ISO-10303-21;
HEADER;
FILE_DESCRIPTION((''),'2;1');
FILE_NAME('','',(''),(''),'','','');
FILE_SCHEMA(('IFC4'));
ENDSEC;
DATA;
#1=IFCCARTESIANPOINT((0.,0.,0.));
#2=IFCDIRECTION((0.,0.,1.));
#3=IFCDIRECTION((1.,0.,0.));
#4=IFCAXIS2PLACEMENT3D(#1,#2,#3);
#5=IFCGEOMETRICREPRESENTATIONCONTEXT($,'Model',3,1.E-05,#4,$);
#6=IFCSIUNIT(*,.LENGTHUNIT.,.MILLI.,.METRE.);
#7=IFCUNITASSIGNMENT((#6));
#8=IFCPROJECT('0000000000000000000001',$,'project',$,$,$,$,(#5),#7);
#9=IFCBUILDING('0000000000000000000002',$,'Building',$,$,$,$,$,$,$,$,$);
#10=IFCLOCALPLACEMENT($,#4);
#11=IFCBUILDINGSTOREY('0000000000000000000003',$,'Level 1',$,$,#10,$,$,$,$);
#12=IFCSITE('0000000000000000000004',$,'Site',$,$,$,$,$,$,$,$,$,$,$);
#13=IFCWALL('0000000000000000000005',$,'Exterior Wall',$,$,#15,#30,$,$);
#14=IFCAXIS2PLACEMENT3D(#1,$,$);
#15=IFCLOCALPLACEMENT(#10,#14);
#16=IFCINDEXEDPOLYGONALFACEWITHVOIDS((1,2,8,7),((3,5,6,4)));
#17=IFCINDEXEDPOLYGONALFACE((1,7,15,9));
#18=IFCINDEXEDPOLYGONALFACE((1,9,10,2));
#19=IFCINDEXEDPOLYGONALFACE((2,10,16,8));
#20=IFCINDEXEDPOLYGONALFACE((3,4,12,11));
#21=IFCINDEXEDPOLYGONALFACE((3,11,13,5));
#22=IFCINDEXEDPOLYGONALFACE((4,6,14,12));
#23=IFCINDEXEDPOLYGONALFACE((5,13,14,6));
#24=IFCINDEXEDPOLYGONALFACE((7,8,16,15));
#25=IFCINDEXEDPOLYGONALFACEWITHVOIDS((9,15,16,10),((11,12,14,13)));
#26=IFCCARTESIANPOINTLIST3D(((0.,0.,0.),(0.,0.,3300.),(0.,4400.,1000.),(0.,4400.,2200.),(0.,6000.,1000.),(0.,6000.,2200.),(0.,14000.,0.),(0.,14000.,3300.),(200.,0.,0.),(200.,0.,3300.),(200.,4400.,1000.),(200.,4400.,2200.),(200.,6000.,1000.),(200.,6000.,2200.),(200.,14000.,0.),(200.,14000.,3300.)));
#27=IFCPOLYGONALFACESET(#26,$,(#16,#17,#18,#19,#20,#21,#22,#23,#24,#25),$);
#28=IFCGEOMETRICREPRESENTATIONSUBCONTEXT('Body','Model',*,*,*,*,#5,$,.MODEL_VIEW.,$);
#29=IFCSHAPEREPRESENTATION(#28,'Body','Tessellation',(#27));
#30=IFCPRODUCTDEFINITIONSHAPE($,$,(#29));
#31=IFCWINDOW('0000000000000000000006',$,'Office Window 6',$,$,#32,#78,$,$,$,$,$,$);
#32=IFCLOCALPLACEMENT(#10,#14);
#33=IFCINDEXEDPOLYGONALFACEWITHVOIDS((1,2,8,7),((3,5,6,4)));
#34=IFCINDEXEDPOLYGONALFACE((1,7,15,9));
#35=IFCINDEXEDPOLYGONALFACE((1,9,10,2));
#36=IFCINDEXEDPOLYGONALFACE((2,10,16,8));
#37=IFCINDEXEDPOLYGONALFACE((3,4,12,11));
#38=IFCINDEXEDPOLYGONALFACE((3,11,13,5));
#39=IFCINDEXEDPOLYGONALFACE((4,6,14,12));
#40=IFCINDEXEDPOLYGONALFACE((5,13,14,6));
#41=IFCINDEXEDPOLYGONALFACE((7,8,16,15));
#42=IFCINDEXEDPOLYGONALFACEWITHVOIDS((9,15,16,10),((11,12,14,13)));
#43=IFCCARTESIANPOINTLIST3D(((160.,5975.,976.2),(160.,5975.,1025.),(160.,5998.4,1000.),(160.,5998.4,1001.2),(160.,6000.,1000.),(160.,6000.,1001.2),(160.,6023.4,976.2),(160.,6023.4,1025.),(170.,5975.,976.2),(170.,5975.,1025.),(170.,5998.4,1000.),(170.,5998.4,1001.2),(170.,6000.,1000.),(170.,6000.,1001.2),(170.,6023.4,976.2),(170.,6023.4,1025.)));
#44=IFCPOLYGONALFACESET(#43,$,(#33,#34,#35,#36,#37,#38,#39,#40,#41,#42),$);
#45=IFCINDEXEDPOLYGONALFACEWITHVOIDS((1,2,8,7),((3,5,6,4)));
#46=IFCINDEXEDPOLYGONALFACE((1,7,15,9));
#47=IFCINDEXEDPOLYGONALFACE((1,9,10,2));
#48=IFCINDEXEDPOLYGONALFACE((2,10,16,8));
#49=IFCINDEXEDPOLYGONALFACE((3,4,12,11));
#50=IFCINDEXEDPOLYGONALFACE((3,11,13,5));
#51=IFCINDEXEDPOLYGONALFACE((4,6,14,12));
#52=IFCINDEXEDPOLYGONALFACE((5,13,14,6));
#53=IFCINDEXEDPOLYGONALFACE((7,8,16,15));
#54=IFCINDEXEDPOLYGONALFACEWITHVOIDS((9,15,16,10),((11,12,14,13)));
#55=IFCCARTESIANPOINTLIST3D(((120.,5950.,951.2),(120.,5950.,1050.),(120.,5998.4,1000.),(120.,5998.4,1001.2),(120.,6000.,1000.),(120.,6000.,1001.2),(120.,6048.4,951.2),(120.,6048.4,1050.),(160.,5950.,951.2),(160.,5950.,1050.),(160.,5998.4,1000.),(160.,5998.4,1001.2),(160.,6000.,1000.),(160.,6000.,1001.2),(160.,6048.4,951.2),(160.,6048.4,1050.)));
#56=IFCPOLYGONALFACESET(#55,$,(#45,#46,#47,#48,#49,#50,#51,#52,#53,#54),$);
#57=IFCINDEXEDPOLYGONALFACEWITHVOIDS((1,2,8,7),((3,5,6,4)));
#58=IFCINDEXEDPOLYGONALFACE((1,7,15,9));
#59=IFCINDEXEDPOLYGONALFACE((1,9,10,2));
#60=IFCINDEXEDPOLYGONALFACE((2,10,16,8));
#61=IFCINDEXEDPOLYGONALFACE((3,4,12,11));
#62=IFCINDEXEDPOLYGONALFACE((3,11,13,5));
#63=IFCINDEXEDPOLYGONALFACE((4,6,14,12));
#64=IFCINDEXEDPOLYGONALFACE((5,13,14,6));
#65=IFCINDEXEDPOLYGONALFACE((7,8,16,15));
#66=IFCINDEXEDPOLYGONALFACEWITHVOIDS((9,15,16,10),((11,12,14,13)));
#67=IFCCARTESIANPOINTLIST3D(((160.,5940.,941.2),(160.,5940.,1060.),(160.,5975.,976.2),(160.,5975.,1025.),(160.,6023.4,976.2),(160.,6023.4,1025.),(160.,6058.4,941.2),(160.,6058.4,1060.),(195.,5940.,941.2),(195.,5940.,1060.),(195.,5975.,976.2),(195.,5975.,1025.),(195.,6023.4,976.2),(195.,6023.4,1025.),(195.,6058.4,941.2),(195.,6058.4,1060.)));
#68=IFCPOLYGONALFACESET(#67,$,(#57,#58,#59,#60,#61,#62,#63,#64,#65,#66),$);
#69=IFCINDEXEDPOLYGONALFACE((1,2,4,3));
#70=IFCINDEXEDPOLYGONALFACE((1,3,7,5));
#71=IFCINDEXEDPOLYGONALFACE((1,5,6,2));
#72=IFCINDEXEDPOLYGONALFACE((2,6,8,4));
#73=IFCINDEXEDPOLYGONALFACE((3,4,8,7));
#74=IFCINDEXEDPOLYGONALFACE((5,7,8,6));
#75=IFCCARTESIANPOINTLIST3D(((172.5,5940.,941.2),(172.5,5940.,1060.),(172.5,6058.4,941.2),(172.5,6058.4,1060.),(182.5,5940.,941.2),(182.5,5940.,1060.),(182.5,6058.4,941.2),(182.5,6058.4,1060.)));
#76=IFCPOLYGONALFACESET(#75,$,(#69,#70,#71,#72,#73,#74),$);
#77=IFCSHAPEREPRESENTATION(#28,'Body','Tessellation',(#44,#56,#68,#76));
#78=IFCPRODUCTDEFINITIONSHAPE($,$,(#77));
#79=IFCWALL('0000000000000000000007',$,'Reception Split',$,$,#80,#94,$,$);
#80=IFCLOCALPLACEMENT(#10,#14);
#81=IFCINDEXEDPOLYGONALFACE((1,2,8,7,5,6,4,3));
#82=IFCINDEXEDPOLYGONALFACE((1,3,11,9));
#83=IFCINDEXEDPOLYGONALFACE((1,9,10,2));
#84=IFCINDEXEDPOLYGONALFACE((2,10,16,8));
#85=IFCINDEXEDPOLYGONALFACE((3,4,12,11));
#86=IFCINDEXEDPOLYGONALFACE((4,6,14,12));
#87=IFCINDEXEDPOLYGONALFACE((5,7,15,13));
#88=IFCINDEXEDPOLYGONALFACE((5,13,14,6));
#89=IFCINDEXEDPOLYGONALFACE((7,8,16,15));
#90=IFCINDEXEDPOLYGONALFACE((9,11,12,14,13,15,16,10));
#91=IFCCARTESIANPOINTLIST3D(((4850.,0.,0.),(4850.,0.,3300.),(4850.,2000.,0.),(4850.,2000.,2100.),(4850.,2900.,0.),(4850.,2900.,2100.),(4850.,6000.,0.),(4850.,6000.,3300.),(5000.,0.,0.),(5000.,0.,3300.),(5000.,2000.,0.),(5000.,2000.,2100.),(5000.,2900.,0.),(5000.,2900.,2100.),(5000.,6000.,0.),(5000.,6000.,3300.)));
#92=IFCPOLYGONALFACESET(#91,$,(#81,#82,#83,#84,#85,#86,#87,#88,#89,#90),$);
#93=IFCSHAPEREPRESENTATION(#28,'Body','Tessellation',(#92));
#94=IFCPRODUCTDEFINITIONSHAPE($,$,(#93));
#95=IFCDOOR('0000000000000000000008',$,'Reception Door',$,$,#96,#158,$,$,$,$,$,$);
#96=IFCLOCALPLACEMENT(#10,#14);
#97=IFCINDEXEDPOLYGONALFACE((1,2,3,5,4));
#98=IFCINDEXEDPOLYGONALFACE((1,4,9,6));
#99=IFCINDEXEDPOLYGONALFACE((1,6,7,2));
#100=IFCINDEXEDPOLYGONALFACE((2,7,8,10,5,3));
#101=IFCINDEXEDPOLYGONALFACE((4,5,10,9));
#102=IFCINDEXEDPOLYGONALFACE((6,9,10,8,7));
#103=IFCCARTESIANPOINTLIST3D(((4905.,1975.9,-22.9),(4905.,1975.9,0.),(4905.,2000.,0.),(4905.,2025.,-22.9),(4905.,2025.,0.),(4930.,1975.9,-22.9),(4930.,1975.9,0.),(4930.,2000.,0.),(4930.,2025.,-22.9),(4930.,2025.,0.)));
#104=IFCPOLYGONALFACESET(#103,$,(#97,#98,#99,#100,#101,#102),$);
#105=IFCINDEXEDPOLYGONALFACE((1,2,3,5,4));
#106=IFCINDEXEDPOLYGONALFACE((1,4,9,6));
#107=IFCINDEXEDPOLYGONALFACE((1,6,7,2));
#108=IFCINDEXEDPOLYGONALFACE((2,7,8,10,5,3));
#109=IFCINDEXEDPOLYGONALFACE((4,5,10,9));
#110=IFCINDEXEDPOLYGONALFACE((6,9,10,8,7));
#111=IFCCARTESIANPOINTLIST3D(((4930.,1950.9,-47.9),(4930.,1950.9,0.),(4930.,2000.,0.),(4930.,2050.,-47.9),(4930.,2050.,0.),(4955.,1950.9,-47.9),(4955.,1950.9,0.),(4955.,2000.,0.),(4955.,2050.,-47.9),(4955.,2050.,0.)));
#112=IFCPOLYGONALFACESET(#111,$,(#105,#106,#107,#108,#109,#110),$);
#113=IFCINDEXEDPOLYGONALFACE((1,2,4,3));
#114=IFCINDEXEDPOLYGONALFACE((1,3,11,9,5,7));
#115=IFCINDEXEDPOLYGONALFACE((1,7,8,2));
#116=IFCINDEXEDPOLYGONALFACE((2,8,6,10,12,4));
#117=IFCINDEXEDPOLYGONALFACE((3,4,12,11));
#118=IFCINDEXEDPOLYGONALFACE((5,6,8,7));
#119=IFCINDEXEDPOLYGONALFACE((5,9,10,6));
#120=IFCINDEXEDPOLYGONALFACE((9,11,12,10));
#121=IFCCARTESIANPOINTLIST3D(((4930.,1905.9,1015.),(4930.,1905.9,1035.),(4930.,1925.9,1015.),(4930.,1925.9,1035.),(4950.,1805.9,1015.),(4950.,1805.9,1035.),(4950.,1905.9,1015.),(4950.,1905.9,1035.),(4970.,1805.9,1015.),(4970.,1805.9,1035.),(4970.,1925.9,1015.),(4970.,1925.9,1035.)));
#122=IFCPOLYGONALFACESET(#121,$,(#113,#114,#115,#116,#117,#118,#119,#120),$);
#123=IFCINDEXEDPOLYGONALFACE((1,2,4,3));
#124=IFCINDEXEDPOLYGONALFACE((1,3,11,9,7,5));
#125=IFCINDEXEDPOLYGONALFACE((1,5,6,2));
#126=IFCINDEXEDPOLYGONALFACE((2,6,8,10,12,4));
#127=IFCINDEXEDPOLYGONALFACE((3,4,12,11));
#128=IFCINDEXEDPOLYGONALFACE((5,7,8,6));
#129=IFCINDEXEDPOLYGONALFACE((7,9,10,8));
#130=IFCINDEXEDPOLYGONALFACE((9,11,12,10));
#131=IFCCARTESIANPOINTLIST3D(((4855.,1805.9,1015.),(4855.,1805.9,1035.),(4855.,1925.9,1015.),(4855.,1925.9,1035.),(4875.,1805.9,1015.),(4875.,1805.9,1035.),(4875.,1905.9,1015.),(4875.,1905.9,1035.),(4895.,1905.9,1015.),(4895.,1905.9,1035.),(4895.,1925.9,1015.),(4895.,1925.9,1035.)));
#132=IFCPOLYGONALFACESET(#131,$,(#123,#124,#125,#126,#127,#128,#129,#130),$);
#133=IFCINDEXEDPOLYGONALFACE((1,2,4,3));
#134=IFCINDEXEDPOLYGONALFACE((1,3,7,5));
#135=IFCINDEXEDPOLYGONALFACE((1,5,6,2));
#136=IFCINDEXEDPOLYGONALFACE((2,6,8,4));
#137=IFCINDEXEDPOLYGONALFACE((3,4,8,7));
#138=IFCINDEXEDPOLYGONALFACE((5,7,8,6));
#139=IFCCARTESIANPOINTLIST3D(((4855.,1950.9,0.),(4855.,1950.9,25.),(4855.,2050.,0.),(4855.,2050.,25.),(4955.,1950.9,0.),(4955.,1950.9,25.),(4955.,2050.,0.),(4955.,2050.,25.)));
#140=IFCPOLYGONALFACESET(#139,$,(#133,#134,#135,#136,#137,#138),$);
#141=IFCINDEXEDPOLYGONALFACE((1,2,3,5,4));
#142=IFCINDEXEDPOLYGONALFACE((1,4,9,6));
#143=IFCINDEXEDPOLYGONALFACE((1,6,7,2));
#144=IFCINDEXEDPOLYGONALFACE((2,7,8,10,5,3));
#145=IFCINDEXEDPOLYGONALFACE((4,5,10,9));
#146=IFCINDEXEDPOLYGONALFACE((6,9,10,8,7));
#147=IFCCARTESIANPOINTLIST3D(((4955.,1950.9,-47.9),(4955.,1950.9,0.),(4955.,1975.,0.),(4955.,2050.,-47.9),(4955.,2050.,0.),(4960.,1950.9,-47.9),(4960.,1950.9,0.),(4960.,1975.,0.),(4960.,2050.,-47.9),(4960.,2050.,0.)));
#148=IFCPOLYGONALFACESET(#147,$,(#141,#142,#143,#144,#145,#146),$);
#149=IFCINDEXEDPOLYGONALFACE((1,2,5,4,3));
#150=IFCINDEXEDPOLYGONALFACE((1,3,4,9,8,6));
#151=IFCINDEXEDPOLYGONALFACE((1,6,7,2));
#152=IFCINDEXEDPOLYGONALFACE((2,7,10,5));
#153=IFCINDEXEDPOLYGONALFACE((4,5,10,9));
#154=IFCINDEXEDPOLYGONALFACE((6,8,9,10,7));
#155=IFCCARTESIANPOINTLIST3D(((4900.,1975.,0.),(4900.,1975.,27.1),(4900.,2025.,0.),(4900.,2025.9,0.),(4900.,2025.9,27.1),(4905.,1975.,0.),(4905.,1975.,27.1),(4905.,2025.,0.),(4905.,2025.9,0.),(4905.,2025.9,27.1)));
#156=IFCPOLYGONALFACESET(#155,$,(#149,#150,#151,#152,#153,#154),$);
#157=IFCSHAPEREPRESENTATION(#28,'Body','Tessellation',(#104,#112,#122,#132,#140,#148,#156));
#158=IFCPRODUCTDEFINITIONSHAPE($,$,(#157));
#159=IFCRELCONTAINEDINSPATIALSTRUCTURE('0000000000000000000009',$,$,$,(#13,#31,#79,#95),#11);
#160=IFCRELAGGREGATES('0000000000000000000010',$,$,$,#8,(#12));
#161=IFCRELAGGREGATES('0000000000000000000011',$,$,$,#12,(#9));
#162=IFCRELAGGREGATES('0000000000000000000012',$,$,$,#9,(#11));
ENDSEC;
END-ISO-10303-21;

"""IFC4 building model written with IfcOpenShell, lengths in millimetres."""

from ifc_helpers import new_model, si_unit, frame, origin_with_axes, place, context, subcontext, project, spatial, line, indexed_curve, outline, extrude, element, fill, save


model = new_model("IFC4")

# Units and contexts
model_context = context("Model", 3, precision=1e-05, world=origin_with_axes())
body_context = subcontext(model_context, "Body", "Model", "MODEL_VIEW")
ifc_project = project(units=[si_unit("LENGTHUNIT", "METRE", prefix="MILLI")], contexts=[model_context])

# Site, building, storey
site = spatial("IfcSite", under=ifc_project, Name="Site")
building = spatial("IfcBuilding", under=site, Name="Building")
storey_placement = place(None, origin_with_axes())
storey = spatial("IfcBuildingStorey", under=building, at=storey_placement, Name="Level 1")

# Wall, opening, window
wall_1_placement = place(storey_placement, frame((0.0, 14000.0, 0.0), z_axis=(0.0, 0.0, 1.0), x_axis=(0.0, -1.0, 0.0)))
wall_1 = element("IfcWall", 1, at=wall_1_placement, inside=storey, Name="Exterior Wall", context=body_context, shape_type="SweptSolid", body=[
    extrude(outline(indexed_curve([(0.0, 0.0), (0.0, 200.0), (14000.0, 200.0), (14000.0, 0.0), (0.0, 0.0)], self_intersect=False)), origin_with_axes(), (0.0, 0.0, 1.0), 3300.0),
])
opening_1_placement = place(wall_1_placement, frame((8000.0, -100.0, 1000.0), z_axis=(0.0, 0.0, 1.0), x_axis=(1.0, 0.0, 0.0)))
opening_1 = element("IfcOpeningElement", 2, at=opening_1_placement, cuts=wall_1, context=body_context, shape_type="SweptSolid", body=[
    extrude(outline(indexed_curve([(0.0, 0.0), (0.0, 400.0), (1600.0, 400.0), (1600.0, 0.0), (0.0, 0.0)], self_intersect=False)), origin_with_axes(), (0.0, 0.0, 1.0), 1200.0),
])
window_1_placement = place(opening_1_placement, frame((0.0, 170.0, 0.0), z_axis=(0.0, 0.0, 1.0), x_axis=(1.0, 0.0, 0.0)))
window_1 = element("IfcWindow", 3, at=window_1_placement, inside=storey, Name="Office Window 6", context=body_context, shape_type="SweptSolid", body=[
    extrude(outline(indexed_curve([(0.0, 0.0), (1.6, 0.0), (1.6, 1.2), (0.0, 1.2)], segments=[line(1, 2, 3, 4, 1)]), holes=[indexed_curve([(25.0, 25.0), (-23.4, 25.0), (-23.4, -23.8), (25.0, -23.8)], segments=[line(1, 2, 3, 4, 1)])]), frame((0.0, 90.0, 0.0), z_axis=(0.0, -1.0, 0.0), x_axis=(1.0, 0.0, 0.0)), (0.0, 0.0, -1.0), 10.0),
    extrude(outline(indexed_curve([(0.0, 0.0), (1.6, 0.0), (1.6, 1.2), (0.0, 1.2)], segments=[line(1, 2, 3, 4, 1)]), holes=[indexed_curve([(50.0, 50.0), (-48.4, 50.0), (-48.4, -48.8), (50.0, -48.8)], segments=[line(1, 2, 3, 4, 1)])]), frame((0.0, 50.0, 0.0), z_axis=(0.0, -1.0, 0.0), x_axis=(1.0, 0.0, 0.0)), (0.0, 0.0, -1.0), 40.0),
    extrude(outline(indexed_curve([(0.0, 0.0), (-48.4, 0.0), (-48.4, -48.8), (0.0, -48.8)], segments=[line(1, 2, 3, 4, 1)]), holes=[indexed_curve([(35.0, 35.0), (-83.4, 35.0), (-83.4, -83.8), (35.0, -83.8)], segments=[line(1, 2, 3, 4, 1)])]), frame((25.0, 90.0, 25.0), z_axis=(0.0, -1.0, 0.0), x_axis=(1.0, 0.0, 0.0)), (0.0, 0.0, -1.0), 35.0),
    extrude(outline(indexed_curve([(35.0, 35.0), (-83.4, 35.0), (-83.4, -83.8), (35.0, -83.8)], segments=[line(1, 2, 3, 4, 1)])), frame((25.0, 102.5, 25.0), z_axis=(0.0, -1.0, 0.0), x_axis=(1.0, 0.0, 0.0)), (0.0, 0.0, -1.0), 10.0),
])
fill(opening_1, window_1)

# Wall, opening, door
wall_2_placement = place(storey_placement, frame((5000.0, 0.0, 0.0), z_axis=(0.0, 0.0, 1.0), x_axis=(0.0, 1.0, 0.0)))
wall_2 = element("IfcWall", 4, at=wall_2_placement, inside=storey, Name="Reception Split", context=body_context, shape_type="SweptSolid", body=[
    extrude(outline(indexed_curve([(0.0, 0.0), (0.0, 150.0), (6000.0, 150.0), (6000.0, 0.0), (0.0, 0.0)], self_intersect=False)), origin_with_axes(), (0.0, 0.0, 1.0), 3300.0),
])
opening_2_placement = place(wall_2_placement, frame((2000.0, -100.0, 0.0), z_axis=(0.0, 0.0, 1.0), x_axis=(1.0, 0.0, 0.0)))
opening_2 = element("IfcOpeningElement", 5, at=opening_2_placement, cuts=wall_2, context=body_context, shape_type="SweptSolid", body=[
    extrude(outline(indexed_curve([(0.0, 0.0), (0.0, 350.0), (900.0, 350.0), (900.0, 0.0), (0.0, 0.0)], self_intersect=False)), origin_with_axes(), (0.0, 0.0, 1.0), 2100.0),
])
door_1_placement = place(opening_2_placement, frame((0.0, 145.0, 0.0), z_axis=(0.0, 0.0, 1.0), x_axis=(1.0, 0.0, 0.0)))
door_1 = element("IfcDoor", 6, at=door_1_placement, inside=storey, Name="Reception Door", context=body_context, shape_type="SweptSolid", body=[
    extrude(outline(indexed_curve([(0.0, 0.0), (0.0, 2.1), (0.9, 2.1), (0.9, 0.0), (-24.1, 0.0), (-24.1, -22.9), (25.0, -22.9), (25.0, 0.0)], segments=[line(1, 2, 3, 4, 5, 6, 7, 8, 1)])), frame((0.0, 25.0, 0.0), z_axis=(0.0, -1.0, 0.0), x_axis=(1.0, 0.0, 0.0)), (0.0, 0.0, -1.0), 25.0),
    extrude(outline(indexed_curve([(0.0, 0.0), (0.0, 2.1), (0.9, 2.1), (0.9, 0.0), (-49.1, 0.0), (-49.1, -47.9), (50.0, -47.9), (50.0, 0.0)], segments=[line(1, 2, 3, 4, 5, 6, 7, 8, 1)])), frame((0.0, 0.0, 0.0), z_axis=(0.0, -1.0, 0.0), x_axis=(1.0, 0.0, 0.0)), (0.0, 0.0, -1.0), 25.0),
    extrude(outline(indexed_curve([(0.0, 0.0), (-49.1, 0.0), (-49.1, 35.0), (0.0, 35.0)], segments=[line(1, 2, 3, 4, 1)])), frame((25.0, 25.0, 25.0), z_axis=(0.0, 0.0, 1.0), x_axis=(1.0, 0.0, 0.0)), (0.0, 0.0, 1.0), -47.9),
    extrude(outline(indexed_curve([(0.0, 0.0), (0.0, -40.0), (-120.0, -40.0), (-120.0, -20.0), (-20.0, -20.0), (-20.0, 0.0)], segments=[line(1, 2, 3, 4, 5, 6, 1)])), frame((-74.1, 25.0, 1015.0), z_axis=(0.0, 0.0, 1.0), x_axis=(1.0, 0.0, 0.0)), (0.0, 0.0, 1.0), 20.0),
    extrude(outline(indexed_curve([(0.0, 0.0), (0.0, 40.0), (-120.0, 40.0), (-120.0, 20.0), (-20.0, 20.0), (-20.0, 0.0)], segments=[line(1, 2, 3, 4, 5, 6, 1)])), frame((-74.1, 60.0, 1015.0), z_axis=(0.0, 0.0, 1.0), x_axis=(1.0, 0.0, 0.0)), (0.0, 0.0, 1.0), 20.0),
    extrude(outline(indexed_curve([(0.0, 0.0), (-99.1, 0.0), (-99.1, 100.0), (0.0, 100.0)], segments=[line(1, 2, 3, 4, 1)])), frame((50.0, 0.0, 0.0), z_axis=(0.0, 0.0, 1.0), x_axis=(1.0, 0.0, 0.0)), (0.0, 0.0, 1.0), 25.0),
    extrude(outline(indexed_curve([(0.0, 0.0), (0.0, 27.1), (50.9, 27.1), (50.9, 0.0), (-24.1, 0.0), (-24.1, -47.9), (75.0, -47.9), (75.0, 0.0)], segments=[line(1, 2, 3, 4, 5, 6, 7, 8, 1)])), frame((-25.0, -5.0, 0.0), z_axis=(0.0, -1.0, 0.0), x_axis=(1.0, 0.0, 0.0)), (0.0, 0.0, -1.0), 5.0),
    extrude(outline(indexed_curve([(0.0, 0.0), (0.0, 27.1), (50.9, 27.1), (50.9, 0.0), (0.9, 0.0), (0.9, -22.9), (50.0, -22.9), (50.0, 0.0)], segments=[line(1, 2, 3, 4, 5, 6, 7, 8, 1)])), frame((-25.0, 50.0, 0.0), z_axis=(0.0, -1.0, 0.0), x_axis=(1.0, 0.0, 0.0)), (0.0, 0.0, -1.0), 5.0),
])
fill(opening_2, door_1)

save(model, "model.ifc")
